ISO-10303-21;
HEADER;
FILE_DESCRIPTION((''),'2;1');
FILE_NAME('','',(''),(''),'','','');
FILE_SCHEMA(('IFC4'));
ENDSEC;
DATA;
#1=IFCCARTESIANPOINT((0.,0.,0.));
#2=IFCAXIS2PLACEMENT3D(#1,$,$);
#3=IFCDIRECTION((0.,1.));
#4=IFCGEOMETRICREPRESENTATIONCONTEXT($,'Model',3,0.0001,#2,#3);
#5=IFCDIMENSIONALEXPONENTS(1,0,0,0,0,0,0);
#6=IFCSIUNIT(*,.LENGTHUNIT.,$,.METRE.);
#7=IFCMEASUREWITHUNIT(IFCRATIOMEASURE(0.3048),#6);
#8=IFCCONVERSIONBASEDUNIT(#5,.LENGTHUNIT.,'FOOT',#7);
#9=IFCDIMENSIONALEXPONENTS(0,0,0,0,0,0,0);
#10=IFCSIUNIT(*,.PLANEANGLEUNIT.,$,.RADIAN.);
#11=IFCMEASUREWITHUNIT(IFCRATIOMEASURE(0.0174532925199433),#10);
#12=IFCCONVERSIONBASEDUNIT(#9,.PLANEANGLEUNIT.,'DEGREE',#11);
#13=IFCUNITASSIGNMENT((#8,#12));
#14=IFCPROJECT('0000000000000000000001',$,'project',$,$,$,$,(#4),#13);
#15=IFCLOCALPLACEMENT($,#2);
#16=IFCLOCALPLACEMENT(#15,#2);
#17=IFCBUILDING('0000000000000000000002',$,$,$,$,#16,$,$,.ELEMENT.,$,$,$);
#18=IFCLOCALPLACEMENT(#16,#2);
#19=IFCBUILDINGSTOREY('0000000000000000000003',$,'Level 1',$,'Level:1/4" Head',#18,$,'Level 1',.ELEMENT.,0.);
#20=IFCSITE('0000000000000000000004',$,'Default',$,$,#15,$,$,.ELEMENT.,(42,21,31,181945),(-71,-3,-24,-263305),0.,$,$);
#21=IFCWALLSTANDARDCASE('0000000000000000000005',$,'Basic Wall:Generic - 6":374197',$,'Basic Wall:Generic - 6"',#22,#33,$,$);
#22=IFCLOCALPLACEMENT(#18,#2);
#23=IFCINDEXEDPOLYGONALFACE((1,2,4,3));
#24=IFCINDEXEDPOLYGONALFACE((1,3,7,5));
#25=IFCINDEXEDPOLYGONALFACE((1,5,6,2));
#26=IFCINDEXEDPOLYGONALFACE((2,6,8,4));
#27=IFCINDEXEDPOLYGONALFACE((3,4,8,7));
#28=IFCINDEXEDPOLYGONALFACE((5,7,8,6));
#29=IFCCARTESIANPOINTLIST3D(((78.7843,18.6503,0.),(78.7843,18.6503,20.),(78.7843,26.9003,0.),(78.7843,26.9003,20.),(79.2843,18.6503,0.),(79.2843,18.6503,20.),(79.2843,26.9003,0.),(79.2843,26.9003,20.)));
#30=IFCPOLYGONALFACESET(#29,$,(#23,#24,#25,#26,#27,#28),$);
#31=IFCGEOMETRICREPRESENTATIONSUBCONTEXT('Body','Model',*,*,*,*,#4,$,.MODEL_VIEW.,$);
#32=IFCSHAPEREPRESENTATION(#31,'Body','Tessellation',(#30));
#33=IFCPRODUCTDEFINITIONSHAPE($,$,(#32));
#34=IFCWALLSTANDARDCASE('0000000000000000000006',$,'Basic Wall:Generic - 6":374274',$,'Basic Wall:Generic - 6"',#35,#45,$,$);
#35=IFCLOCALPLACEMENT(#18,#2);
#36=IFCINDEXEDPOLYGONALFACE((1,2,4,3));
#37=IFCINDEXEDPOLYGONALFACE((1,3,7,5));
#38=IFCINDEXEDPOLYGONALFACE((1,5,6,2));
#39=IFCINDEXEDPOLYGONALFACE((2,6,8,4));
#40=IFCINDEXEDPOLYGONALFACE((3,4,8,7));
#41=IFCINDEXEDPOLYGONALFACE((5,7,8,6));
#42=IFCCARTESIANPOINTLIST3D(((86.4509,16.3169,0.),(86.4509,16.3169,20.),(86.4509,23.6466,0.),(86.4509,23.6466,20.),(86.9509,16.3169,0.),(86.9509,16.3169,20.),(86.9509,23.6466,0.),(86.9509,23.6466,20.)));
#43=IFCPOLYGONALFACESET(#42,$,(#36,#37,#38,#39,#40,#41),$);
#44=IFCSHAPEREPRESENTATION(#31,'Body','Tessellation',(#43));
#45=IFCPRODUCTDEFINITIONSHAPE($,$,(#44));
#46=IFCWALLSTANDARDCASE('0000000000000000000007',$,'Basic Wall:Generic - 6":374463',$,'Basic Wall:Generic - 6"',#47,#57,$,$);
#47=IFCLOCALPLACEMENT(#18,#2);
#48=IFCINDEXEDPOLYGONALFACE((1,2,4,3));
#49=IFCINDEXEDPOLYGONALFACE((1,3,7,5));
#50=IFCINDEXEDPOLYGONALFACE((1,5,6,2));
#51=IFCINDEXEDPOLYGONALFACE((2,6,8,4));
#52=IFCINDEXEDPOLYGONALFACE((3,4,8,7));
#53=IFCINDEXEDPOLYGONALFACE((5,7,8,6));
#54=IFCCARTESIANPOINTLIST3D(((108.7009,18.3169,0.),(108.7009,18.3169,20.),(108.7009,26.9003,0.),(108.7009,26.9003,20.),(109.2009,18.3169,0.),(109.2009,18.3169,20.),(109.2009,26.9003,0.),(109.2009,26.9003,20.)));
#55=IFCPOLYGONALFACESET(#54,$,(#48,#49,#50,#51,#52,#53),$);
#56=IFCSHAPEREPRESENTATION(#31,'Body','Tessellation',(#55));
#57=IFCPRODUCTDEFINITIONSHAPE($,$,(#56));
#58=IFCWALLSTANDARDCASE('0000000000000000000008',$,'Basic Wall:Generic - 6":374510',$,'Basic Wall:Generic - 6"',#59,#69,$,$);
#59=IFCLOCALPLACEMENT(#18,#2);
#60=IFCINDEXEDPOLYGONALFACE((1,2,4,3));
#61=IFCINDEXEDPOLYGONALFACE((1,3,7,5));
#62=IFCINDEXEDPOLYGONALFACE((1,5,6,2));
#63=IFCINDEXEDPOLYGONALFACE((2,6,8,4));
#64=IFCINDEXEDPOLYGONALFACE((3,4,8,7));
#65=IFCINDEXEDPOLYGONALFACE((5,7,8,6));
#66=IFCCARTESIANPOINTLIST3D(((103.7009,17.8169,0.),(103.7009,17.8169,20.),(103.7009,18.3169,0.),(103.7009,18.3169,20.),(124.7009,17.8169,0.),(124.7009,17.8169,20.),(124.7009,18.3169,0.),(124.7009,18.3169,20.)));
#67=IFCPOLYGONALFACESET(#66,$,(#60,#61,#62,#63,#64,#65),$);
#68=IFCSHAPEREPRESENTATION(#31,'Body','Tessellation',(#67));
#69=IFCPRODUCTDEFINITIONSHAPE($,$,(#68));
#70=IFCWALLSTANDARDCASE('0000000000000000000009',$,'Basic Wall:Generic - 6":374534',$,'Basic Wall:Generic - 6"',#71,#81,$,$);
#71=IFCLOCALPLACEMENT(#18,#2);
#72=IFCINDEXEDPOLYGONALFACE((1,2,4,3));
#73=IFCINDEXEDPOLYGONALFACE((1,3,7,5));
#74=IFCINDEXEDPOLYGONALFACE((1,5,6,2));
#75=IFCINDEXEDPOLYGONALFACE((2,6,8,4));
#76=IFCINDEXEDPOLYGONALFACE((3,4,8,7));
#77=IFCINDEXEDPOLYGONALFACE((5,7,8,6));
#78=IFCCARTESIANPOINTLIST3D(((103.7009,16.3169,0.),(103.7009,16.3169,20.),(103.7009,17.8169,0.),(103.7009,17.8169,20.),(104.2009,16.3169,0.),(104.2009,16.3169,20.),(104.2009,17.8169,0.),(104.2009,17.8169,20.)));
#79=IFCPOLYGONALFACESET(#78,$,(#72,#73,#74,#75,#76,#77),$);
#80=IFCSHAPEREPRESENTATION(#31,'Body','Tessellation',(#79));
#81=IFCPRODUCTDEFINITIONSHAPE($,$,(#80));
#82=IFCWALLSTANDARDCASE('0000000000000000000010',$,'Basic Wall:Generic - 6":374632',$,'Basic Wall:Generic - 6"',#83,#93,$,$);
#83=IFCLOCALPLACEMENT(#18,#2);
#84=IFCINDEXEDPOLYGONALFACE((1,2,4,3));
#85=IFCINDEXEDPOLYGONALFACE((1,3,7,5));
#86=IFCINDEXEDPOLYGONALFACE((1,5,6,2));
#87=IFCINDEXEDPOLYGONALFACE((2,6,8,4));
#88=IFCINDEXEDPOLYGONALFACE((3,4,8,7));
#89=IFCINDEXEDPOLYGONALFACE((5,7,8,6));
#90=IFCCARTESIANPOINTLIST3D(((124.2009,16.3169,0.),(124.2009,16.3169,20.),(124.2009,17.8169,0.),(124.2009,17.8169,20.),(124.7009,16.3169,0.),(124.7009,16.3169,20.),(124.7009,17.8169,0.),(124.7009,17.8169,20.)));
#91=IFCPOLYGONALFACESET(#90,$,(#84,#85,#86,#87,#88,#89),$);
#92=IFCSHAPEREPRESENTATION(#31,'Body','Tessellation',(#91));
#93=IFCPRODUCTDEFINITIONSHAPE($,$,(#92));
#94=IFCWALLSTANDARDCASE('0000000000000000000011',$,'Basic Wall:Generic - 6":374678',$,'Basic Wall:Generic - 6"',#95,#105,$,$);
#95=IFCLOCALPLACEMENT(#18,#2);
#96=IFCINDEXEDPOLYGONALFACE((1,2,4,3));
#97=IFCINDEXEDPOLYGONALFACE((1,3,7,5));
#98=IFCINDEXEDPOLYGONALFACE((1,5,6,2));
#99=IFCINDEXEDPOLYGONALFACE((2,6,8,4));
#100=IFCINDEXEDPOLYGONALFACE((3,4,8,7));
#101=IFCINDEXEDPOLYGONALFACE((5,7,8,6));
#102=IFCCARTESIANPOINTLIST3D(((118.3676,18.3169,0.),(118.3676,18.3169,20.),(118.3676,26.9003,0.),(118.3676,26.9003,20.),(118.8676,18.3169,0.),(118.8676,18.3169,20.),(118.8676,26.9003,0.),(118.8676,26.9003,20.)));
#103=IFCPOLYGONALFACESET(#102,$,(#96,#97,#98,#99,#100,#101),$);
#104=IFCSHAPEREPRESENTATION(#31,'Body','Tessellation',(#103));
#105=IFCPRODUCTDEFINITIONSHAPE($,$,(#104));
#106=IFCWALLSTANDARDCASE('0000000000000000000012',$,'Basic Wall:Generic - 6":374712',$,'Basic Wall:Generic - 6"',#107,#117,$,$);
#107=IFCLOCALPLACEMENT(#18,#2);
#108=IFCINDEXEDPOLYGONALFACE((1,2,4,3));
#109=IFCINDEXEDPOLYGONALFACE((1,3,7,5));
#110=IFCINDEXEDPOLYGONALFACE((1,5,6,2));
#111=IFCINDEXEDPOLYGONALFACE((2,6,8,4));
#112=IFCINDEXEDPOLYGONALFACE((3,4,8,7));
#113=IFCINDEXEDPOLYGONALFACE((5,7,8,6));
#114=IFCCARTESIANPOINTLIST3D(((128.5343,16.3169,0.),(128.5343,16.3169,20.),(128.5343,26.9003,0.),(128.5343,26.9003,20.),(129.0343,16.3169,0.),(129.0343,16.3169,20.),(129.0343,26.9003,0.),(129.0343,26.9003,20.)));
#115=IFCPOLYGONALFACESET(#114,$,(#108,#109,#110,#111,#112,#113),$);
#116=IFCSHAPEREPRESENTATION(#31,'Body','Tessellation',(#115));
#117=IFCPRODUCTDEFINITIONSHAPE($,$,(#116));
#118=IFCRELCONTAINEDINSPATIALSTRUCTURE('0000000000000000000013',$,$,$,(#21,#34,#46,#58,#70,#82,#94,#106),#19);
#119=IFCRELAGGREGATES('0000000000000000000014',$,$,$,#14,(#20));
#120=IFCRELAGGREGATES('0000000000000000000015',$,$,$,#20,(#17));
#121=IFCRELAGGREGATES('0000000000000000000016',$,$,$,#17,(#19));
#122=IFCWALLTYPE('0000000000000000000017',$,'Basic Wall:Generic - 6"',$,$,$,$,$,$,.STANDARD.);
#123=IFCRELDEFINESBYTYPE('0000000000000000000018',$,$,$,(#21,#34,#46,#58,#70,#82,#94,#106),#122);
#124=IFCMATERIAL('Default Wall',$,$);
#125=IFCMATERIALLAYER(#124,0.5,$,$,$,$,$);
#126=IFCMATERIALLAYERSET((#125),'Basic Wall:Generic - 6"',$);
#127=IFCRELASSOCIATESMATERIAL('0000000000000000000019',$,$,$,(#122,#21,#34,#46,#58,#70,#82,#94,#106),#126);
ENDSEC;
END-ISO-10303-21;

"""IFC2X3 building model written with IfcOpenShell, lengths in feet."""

from ifc_helpers import new_model, entity, si_unit, converted_unit, direction, frame, frame_2d, origin, place, context, subcontext, project, spatial, rectangle, extrude, material, layer, layer_set, layer_usage, type_object, element, save


model = new_model("IFC2X3")

# Units and contexts
model_context = context("Model", 3, precision=0.0001, world=origin(), true_north=direction((0.0, 1.0)))
body_context = subcontext(model_context, "Body", "Model", "MODEL_VIEW")
ifc_project = project(units=[converted_unit("LENGTHUNIT", "FOOT", entity("IfcRatioMeasure", 0.3048), si_unit("LENGTHUNIT", "METRE"), dimensions=[1, 0, 0, 0, 0, 0, 0]), converted_unit("PLANEANGLEUNIT", "DEGREE", entity("IfcRatioMeasure", 0.0174532925199433), si_unit("PLANEANGLEUNIT", "RADIAN"), dimensions=[0, 0, 0, 0, 0, 0, 0])], contexts=[model_context])

# Site, building, storey
site_placement = place(None, origin())
site = spatial("IfcSite", under=ifc_project, at=site_placement, Name="Default", CompositionType="ELEMENT", RefLatitude=(42, 21, 31, 181945), RefLongitude=(-71, -3, -24, -263305), RefElevation=0.0)
building_placement = place(site_placement, origin())
building = spatial("IfcBuilding", under=site, at=building_placement, CompositionType="ELEMENT")
storey_placement = place(building_placement, origin())
storey = spatial("IfcBuildingStorey", under=building, at=storey_placement, Name="Level 1", ObjectType="Level:1/4\" Head", LongName="Level 1", CompositionType="ELEMENT", Elevation=0.0)

# Walls
ifc_material = material(Name="Default Wall")
ifc_layer_1 = layer(ifc_material, 0.5)
ifc_layer_set_1 = layer_set([ifc_layer_1], Name="Basic Wall:Generic - 6\"")
wall_type_1 = type_object("IfcWallType", Name="Basic Wall:Generic - 6\"", PredefinedType="STANDARD", material=ifc_layer_set_1)
ifc_layer_usage_1 = layer_usage(ifc_layer_set_1, "AXIS2", "NEGATIVE", 0.25)
wall_1_placement = place(storey_placement, frame((79.0343, 26.9003, 0.0), z_axis=(0.0, 0.0, 1.0), x_axis=(0.0, -1.0, 0.0)))
element("IfcWallStandardCase", 1, at=wall_1_placement, inside=storey, type_object=wall_type_1, material=ifc_layer_usage_1, Name="Basic Wall:Generic - 6\":374197", ObjectType="Basic Wall:Generic - 6\"", context=body_context, shape_type="SweptSolid", body=[
    extrude(rectangle(XDim=8.25, YDim=0.5, at=frame_2d((4.125, 0.0), x_axis=(-1.0, 0.0))), origin(), (0.0, 0.0, 1.0), 20.0),
])
ifc_layer_usage_2 = layer_usage(ifc_layer_set_1, "AXIS2", "NEGATIVE", 0.25)
wall_2_placement = place(storey_placement, frame((86.7009, 16.3169, 0.0), z_axis=(0.0, 0.0, 1.0), x_axis=(0.0, 1.0, 0.0)))
element("IfcWallStandardCase", 2, at=wall_2_placement, inside=storey, type_object=wall_type_1, material=ifc_layer_usage_2, Name="Basic Wall:Generic - 6\":374274", ObjectType="Basic Wall:Generic - 6\"", context=body_context, shape_type="SweptSolid", body=[
    extrude(rectangle(XDim=7.3297, YDim=0.5, at=frame_2d((3.6648, 0.0), x_axis=(-1.0, 0.0))), origin(), (0.0, 0.0, 1.0), 20.0),
])
ifc_layer_usage_3 = layer_usage(ifc_layer_set_1, "AXIS2", "NEGATIVE", 0.25)
wall_3_placement = place(storey_placement, frame((108.9509, 26.9003, 0.0), z_axis=(0.0, 0.0, 1.0), x_axis=(0.0, -1.0, 0.0)))
element("IfcWallStandardCase", 3, at=wall_3_placement, inside=storey, type_object=wall_type_1, material=ifc_layer_usage_3, Name="Basic Wall:Generic - 6\":374463", ObjectType="Basic Wall:Generic - 6\"", context=body_context, shape_type="SweptSolid", body=[
    extrude(rectangle(XDim=8.5833, YDim=0.5, at=frame_2d((4.2917, 0.0), x_axis=(-1.0, 0.0))), origin(), (0.0, 0.0, 1.0), 20.0),
])
ifc_layer_usage_4 = layer_usage(ifc_layer_set_1, "AXIS2", "NEGATIVE", 0.25)
wall_4_placement = place(storey_placement, frame((124.7009, 18.0669, 0.0), z_axis=(0.0, 0.0, 1.0), x_axis=(-1.0, 0.0, 0.0)))
element("IfcWallStandardCase", 4, at=wall_4_placement, inside=storey, type_object=wall_type_1, material=ifc_layer_usage_4, Name="Basic Wall:Generic - 6\":374510", ObjectType="Basic Wall:Generic - 6\"", context=body_context, shape_type="SweptSolid", body=[
    extrude(rectangle(XDim=21.0, YDim=0.5, at=frame_2d((10.5, 0.0), x_axis=(-1.0, 0.0))), origin(), (0.0, 0.0, 1.0), 20.0),
])
ifc_layer_usage_5 = layer_usage(ifc_layer_set_1, "AXIS2", "NEGATIVE", 0.25)
wall_5_placement = place(storey_placement, frame((103.9509, 17.8169, 0.0), z_axis=(0.0, 0.0, 1.0), x_axis=(0.0, -1.0, 0.0)))
element("IfcWallStandardCase", 5, at=wall_5_placement, inside=storey, type_object=wall_type_1, material=ifc_layer_usage_5, Name="Basic Wall:Generic - 6\":374534", ObjectType="Basic Wall:Generic - 6\"", context=body_context, shape_type="SweptSolid", body=[
    extrude(rectangle(XDim=1.5, YDim=0.5, at=frame_2d((0.75, 0.0), x_axis=(-1.0, 0.0))), origin(), (0.0, 0.0, 1.0), 20.0),
])
ifc_layer_usage_6 = layer_usage(ifc_layer_set_1, "AXIS2", "NEGATIVE", 0.25)
wall_6_placement = place(storey_placement, frame((124.4509, 17.8169, 0.0), z_axis=(0.0, 0.0, 1.0), x_axis=(0.0, -1.0, 0.0)))
element("IfcWallStandardCase", 6, at=wall_6_placement, inside=storey, type_object=wall_type_1, material=ifc_layer_usage_6, Name="Basic Wall:Generic - 6\":374632", ObjectType="Basic Wall:Generic - 6\"", context=body_context, shape_type="SweptSolid", body=[
    extrude(rectangle(XDim=1.5, YDim=0.5, at=frame_2d((0.75, 0.0), x_axis=(-1.0, 0.0))), origin(), (0.0, 0.0, 1.0), 20.0),
])
ifc_layer_usage_7 = layer_usage(ifc_layer_set_1, "AXIS2", "NEGATIVE", 0.25)
wall_7_placement = place(storey_placement, frame((118.6176, 26.9003, 0.0), z_axis=(0.0, 0.0, 1.0), x_axis=(0.0, -1.0, 0.0)))
element("IfcWallStandardCase", 7, at=wall_7_placement, inside=storey, type_object=wall_type_1, material=ifc_layer_usage_7, Name="Basic Wall:Generic - 6\":374678", ObjectType="Basic Wall:Generic - 6\"", context=body_context, shape_type="SweptSolid", body=[
    extrude(rectangle(XDim=8.5833, YDim=0.5, at=frame_2d((4.2917, 0.0), x_axis=(-1.0, 0.0))), origin(), (0.0, 0.0, 1.0), 20.0),
])
ifc_layer_usage_8 = layer_usage(ifc_layer_set_1, "AXIS2", "NEGATIVE", 0.25)
wall_8_placement = place(storey_placement, frame((128.7843, 26.9003, 0.0), z_axis=(0.0, 0.0, 1.0), x_axis=(0.0, -1.0, 0.0)))
element("IfcWallStandardCase", 8, at=wall_8_placement, inside=storey, type_object=wall_type_1, material=ifc_layer_usage_8, Name="Basic Wall:Generic - 6\":374712", ObjectType="Basic Wall:Generic - 6\"", context=body_context, shape_type="SweptSolid", body=[
    extrude(rectangle(XDim=10.5833, YDim=0.5, at=frame_2d((5.2917, 0.0), x_axis=(-1.0, 0.0))), origin(), (0.0, 0.0, 1.0), 20.0),
])

save(model, "model.ifc")
